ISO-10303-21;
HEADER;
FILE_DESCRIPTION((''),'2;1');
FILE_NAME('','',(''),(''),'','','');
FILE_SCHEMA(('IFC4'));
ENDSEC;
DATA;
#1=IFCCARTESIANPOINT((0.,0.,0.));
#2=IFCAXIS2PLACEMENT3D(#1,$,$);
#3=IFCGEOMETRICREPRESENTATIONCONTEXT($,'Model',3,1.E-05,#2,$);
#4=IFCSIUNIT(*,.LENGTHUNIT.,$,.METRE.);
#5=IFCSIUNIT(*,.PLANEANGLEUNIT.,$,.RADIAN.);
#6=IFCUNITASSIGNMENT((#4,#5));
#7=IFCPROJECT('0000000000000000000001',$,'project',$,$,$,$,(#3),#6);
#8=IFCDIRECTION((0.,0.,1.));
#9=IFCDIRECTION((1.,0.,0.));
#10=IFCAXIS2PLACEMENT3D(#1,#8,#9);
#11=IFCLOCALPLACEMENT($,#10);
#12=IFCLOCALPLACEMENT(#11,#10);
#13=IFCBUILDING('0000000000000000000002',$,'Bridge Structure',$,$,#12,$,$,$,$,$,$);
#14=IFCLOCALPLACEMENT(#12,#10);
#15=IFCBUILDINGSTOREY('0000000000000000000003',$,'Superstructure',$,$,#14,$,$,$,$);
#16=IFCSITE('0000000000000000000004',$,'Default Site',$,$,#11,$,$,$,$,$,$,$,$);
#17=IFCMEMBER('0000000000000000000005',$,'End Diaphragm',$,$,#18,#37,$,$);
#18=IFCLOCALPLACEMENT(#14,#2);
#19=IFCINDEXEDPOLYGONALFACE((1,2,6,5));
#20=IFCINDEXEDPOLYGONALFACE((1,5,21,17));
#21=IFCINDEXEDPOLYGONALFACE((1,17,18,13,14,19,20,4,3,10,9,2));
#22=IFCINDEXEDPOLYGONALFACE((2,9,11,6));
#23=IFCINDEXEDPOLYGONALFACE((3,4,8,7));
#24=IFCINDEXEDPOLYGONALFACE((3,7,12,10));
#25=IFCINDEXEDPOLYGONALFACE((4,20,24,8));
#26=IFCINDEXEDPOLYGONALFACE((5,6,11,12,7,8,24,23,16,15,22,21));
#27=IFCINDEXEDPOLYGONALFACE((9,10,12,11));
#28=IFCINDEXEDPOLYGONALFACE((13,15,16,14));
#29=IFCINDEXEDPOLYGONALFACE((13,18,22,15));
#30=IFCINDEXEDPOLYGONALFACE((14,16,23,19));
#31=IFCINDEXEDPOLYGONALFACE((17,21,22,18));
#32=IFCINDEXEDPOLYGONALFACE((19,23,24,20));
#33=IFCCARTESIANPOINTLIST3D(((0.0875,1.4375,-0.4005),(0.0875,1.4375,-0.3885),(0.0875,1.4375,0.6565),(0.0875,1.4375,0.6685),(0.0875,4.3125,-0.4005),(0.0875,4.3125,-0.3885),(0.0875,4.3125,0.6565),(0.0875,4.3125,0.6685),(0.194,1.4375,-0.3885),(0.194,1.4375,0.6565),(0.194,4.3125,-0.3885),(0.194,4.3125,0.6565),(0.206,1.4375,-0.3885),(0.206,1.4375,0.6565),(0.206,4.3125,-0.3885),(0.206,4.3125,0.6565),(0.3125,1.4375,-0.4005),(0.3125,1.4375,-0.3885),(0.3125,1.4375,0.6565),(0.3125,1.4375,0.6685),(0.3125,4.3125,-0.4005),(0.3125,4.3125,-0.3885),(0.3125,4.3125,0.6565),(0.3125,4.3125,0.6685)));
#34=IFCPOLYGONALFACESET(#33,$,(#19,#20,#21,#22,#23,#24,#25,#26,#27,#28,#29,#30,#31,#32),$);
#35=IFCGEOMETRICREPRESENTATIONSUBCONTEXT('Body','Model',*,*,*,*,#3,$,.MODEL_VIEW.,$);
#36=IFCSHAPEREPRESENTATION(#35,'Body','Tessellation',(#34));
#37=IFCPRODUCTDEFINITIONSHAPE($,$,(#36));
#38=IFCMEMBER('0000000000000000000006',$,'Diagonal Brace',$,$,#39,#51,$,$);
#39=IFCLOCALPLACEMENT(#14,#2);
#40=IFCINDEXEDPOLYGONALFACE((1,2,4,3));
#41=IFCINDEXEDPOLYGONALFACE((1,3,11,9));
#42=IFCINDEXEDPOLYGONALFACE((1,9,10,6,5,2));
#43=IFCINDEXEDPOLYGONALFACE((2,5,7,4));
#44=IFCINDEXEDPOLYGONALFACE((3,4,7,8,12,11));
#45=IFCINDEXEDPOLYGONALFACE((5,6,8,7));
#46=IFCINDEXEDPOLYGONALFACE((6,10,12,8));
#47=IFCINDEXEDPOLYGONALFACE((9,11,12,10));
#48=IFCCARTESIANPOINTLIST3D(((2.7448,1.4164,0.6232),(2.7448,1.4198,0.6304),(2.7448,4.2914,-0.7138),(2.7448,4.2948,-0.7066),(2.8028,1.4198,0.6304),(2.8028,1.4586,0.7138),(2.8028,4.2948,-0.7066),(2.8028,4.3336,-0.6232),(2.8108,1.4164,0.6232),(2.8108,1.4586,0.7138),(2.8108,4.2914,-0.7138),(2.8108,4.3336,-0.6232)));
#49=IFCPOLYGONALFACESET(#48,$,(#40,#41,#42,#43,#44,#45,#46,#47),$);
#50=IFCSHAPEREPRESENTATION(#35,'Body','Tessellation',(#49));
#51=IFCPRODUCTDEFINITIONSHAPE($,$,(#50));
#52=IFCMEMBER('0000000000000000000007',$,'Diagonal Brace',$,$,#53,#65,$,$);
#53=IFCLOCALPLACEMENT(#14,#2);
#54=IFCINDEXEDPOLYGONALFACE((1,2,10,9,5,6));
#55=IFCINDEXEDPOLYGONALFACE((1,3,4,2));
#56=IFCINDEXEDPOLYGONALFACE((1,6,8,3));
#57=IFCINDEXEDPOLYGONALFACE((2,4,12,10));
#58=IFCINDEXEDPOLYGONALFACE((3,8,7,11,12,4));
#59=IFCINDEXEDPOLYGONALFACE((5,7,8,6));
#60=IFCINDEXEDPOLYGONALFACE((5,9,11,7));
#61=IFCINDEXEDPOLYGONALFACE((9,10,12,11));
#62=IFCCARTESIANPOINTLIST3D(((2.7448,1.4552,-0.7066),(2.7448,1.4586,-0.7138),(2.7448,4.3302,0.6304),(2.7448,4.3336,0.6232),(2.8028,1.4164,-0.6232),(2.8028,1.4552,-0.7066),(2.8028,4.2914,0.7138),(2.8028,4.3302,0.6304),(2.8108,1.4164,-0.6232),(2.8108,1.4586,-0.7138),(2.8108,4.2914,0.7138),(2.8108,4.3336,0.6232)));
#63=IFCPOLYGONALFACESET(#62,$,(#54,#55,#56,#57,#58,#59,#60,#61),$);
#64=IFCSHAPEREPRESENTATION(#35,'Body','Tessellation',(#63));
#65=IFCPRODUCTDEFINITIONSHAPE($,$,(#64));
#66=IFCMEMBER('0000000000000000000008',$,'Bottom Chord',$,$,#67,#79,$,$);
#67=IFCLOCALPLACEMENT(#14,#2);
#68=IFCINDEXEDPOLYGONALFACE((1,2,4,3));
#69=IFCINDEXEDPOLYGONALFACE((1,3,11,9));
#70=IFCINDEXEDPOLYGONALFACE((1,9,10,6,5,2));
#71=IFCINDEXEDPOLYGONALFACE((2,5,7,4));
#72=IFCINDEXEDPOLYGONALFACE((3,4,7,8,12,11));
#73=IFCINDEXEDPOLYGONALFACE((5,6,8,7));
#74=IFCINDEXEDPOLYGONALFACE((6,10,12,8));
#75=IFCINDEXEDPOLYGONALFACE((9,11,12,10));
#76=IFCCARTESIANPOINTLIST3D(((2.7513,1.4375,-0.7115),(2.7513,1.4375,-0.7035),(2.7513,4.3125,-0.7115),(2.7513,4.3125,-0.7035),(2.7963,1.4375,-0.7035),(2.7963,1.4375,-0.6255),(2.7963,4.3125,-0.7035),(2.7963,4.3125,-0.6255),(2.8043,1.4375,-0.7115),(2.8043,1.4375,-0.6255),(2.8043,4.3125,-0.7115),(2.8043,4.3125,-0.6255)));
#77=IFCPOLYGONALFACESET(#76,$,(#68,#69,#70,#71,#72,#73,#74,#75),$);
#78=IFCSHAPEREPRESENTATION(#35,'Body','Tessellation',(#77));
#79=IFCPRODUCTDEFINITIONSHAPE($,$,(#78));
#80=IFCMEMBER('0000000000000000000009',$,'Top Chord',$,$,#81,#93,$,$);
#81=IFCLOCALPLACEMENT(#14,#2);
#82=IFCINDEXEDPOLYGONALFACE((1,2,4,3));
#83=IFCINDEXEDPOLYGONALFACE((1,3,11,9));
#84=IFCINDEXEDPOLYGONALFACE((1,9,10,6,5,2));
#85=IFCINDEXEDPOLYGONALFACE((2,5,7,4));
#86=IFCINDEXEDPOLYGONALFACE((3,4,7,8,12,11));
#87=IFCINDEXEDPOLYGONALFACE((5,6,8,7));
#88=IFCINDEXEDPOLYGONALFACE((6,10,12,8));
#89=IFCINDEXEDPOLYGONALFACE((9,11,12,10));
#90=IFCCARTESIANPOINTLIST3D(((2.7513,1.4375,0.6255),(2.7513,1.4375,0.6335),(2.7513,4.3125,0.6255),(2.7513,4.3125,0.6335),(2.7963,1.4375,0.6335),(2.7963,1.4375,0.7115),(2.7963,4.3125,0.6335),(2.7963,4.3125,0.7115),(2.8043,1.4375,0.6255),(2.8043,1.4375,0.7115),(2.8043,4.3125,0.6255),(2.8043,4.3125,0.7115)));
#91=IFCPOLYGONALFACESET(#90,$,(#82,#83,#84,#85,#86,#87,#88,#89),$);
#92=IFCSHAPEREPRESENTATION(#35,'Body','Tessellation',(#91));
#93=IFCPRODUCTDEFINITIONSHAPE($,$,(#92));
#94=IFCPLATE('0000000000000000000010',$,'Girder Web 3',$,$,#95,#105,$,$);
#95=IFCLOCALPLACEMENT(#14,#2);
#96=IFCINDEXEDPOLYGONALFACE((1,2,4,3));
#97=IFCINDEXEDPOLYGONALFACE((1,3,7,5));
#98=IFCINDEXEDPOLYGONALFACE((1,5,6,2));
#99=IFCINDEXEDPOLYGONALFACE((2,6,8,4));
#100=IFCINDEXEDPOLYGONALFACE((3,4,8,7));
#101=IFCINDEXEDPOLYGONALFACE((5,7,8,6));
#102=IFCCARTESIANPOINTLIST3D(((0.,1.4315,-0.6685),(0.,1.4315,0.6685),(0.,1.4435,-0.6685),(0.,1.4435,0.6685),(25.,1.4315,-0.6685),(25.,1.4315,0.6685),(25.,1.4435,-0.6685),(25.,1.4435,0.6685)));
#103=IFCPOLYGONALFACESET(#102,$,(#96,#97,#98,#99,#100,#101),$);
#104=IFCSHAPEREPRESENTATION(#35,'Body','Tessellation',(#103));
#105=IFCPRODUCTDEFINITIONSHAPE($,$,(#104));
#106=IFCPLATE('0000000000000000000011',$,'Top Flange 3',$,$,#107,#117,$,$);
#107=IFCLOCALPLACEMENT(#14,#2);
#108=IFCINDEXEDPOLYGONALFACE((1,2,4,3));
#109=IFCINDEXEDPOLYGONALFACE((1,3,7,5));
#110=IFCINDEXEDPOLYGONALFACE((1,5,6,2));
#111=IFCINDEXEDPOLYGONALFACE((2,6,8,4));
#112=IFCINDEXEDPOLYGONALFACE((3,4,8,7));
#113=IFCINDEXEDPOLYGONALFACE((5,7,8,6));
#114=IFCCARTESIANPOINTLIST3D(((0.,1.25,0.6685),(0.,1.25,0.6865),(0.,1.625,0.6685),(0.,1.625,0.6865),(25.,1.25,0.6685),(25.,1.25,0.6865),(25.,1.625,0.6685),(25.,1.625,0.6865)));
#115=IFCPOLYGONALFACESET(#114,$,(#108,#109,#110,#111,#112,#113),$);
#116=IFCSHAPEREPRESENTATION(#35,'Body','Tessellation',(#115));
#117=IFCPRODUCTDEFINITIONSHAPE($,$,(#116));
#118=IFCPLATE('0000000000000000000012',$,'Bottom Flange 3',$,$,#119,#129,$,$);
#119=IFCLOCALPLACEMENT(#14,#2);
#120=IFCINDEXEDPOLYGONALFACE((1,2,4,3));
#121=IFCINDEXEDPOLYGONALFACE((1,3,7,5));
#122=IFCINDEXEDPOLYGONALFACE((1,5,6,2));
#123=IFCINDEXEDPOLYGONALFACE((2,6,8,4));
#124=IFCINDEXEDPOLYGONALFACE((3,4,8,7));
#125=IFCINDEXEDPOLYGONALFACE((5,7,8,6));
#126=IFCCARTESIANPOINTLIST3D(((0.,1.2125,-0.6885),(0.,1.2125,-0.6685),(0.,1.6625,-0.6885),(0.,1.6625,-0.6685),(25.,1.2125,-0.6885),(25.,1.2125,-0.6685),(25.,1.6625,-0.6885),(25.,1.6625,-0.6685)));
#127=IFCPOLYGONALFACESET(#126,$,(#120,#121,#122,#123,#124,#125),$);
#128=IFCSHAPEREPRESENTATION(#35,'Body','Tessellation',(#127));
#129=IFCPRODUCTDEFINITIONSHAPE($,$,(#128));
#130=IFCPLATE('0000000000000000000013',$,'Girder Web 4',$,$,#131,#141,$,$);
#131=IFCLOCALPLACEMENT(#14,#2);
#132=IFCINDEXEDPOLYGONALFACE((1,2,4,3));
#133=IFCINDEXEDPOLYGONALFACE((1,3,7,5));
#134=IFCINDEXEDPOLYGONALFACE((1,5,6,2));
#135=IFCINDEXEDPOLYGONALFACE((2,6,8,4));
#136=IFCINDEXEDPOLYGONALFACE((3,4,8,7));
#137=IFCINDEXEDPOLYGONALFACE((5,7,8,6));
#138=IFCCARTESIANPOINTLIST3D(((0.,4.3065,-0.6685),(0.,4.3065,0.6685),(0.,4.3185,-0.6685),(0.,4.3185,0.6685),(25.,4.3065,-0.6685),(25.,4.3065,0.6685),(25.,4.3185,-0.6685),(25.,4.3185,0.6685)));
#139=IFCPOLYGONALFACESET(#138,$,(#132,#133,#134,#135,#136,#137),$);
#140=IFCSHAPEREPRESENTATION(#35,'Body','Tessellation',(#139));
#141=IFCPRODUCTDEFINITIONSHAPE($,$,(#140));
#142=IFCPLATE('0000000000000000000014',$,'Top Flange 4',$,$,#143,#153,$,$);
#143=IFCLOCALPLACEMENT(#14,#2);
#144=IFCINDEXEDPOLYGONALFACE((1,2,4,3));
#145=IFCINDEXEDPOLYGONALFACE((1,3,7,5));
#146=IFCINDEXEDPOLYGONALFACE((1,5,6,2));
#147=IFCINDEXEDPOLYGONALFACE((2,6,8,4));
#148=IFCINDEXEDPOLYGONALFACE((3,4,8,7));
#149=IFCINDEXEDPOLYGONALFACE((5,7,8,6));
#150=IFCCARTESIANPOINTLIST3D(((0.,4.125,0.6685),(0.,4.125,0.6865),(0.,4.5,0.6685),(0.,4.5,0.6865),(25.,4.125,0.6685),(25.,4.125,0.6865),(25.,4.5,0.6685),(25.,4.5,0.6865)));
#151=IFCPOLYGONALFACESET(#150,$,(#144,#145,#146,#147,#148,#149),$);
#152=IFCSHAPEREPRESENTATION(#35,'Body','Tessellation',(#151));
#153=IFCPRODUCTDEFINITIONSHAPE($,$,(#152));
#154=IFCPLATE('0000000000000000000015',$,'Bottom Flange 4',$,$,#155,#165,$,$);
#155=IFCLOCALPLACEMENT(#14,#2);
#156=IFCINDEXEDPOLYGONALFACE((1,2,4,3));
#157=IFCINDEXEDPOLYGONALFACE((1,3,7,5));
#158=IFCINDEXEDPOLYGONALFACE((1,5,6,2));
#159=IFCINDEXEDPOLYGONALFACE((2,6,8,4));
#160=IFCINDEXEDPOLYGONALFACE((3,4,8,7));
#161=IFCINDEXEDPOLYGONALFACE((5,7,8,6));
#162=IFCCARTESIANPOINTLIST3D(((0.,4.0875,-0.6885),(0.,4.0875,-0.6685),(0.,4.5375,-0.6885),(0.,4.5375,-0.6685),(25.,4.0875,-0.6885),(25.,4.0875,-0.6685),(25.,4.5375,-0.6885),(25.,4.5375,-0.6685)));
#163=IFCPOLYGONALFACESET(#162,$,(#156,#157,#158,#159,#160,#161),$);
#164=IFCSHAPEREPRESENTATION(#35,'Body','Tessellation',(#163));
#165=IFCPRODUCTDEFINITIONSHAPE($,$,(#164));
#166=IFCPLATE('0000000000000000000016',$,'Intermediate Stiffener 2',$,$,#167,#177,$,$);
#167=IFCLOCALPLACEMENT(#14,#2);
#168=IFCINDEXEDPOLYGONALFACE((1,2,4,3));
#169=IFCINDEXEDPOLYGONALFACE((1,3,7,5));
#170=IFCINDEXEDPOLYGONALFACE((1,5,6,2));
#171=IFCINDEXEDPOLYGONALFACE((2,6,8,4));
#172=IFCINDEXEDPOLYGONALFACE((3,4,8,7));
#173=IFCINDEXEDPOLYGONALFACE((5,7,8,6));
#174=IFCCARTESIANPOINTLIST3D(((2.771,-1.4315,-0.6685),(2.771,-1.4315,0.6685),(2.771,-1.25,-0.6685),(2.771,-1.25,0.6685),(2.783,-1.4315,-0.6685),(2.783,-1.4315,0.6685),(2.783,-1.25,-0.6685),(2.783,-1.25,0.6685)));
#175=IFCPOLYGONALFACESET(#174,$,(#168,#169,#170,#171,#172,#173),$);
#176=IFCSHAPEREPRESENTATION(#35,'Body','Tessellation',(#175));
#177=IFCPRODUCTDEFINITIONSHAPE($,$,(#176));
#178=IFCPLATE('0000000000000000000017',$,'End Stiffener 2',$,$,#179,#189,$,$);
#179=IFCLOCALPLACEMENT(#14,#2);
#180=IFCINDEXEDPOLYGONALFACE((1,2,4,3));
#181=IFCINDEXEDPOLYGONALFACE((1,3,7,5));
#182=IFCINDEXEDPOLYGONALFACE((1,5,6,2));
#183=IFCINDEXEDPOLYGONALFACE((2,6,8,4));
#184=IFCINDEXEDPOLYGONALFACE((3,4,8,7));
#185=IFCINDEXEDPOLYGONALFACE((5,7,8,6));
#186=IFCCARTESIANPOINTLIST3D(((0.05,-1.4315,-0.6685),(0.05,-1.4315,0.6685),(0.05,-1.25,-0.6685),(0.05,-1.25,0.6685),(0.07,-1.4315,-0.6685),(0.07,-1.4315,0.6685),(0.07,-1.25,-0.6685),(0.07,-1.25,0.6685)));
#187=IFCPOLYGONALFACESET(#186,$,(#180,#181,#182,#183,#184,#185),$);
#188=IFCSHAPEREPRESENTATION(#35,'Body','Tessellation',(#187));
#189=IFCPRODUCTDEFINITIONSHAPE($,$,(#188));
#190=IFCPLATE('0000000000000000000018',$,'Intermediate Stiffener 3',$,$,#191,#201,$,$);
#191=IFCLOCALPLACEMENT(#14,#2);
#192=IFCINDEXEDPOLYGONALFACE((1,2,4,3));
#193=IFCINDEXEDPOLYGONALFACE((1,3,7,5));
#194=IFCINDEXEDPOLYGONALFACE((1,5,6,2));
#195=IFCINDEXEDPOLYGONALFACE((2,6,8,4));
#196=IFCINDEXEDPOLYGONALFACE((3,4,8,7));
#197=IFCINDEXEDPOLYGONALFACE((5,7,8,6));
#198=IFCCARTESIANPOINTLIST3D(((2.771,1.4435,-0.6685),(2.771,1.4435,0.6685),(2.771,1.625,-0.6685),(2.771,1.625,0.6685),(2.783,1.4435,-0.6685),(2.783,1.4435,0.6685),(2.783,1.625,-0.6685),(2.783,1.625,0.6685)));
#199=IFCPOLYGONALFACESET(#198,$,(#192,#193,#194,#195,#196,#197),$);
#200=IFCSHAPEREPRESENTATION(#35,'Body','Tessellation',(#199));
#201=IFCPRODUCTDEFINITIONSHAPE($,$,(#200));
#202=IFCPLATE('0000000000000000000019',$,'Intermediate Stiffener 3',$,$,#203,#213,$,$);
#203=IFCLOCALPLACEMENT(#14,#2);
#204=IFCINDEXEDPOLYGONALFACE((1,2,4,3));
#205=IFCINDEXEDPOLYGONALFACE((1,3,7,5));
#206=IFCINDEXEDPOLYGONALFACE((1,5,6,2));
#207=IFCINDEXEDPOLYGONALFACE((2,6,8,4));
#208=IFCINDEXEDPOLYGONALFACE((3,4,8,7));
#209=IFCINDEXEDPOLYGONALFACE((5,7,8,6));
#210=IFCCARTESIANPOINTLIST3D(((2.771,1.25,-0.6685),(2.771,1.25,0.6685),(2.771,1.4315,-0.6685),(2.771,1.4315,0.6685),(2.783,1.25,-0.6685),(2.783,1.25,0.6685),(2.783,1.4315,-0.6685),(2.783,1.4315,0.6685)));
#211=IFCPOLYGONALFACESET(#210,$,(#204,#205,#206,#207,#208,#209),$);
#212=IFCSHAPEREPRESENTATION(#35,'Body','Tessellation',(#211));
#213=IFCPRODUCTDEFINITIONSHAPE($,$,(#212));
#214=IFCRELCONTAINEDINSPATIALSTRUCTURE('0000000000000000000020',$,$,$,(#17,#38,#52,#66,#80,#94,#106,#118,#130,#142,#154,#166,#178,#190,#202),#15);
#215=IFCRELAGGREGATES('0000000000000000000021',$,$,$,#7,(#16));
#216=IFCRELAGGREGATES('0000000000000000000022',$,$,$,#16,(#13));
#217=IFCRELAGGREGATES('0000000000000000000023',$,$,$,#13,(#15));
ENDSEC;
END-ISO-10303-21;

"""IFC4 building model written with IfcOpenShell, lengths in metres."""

from ifc_helpers import new_model, si_unit, frame, origin, origin_with_axes, origin_2d_with_axis, place, context, subcontext, project, spatial, rectangle, i_section, l_section, extrude, element, save


model = new_model("IFC4")

# Units and contexts
model_context = context("Model", 3, precision=1e-05, world=origin())
body_context = subcontext(model_context, "Body", "Model", "MODEL_VIEW")
ifc_project = project(units=[si_unit("LENGTHUNIT", "METRE"), si_unit("PLANEANGLEUNIT", "RADIAN")], contexts=[model_context])

# Site, building, storey
site_placement = place(None, origin_with_axes())
site = spatial("IfcSite", under=ifc_project, at=site_placement, Name="Default Site")
building_placement = place(site_placement, origin_with_axes())
building = spatial("IfcBuilding", under=site, at=building_placement, Name="Bridge Structure")
storey_placement = place(building_placement, origin_with_axes())
storey = spatial("IfcBuildingStorey", under=building, at=storey_placement, Name="Superstructure")

# Members
member_placement = place(storey_placement, frame((0.2, 1.4375, 0.134), z_axis=(0.0, 1.0, 0.0), x_axis=(-1.0, 0.0, 0.0)))
element("IfcMember", 1, at=member_placement, inside=storey, Name="End Diaphragm", context=body_context, shape_type="SweptSolid", body=[
    extrude(i_section(OverallWidth=0.225, OverallDepth=1.069, WebThickness=0.012, FlangeThickness=0.012, at=origin_2d_with_axis()), origin_with_axes(), (0.0, 0.0, 1.0), 2.875),
])
for number, where, z_axis, x_axis, name in (
    (2, (2.7778, 1.4375, 0.6685), (0.0, 0.906746, -0.421676), (-1.0, 0.0, 0.0), "Diagonal Brace"),
    (3, (2.7778, 1.4375, -0.6685), (0.0, 0.906746, 0.421676), (-1.0, 0.0, 0.0), "Diagonal Brace"),
):
    element("IfcMember", number, at=place(storey_placement, frame(where, z_axis=z_axis, x_axis=x_axis)), inside=storey, Name=name, context=body_context, shape_type="SweptSolid", body=[
        extrude(l_section(Depth=0.1, Width=0.066, Thickness=0.008, at=origin_2d_with_axis()), origin_with_axes(), (0.0, 0.0, 1.0), 3.1707),
    ])
for number, where, z_axis, x_axis, name in (
    (4, (2.7778, 1.4375, -0.6685), (0.0, 1.0, 0.0), (-1.0, 0.0, 0.0), "Bottom Chord"),
    (5, (2.7778, 1.4375, 0.6685), (0.0, 1.0, 0.0), (-1.0, 0.0, 0.0), "Top Chord"),
):
    element("IfcMember", number, at=place(storey_placement, frame(where, z_axis=z_axis, x_axis=x_axis)), inside=storey, Name=name, context=body_context, shape_type="SweptSolid", body=[
        extrude(l_section(Depth=0.086, Width=0.053, Thickness=0.008, at=origin_2d_with_axis()), origin_with_axes(), (0.0, 0.0, 1.0), 2.875),
    ])

# Plates
plate_1_placement = place(storey_placement, frame((0.0, 1.4375, 0.0), z_axis=(1.0, 0.0, 0.0), x_axis=(0.0, 1.0, 0.0)))
element("IfcPlate", 6, at=plate_1_placement, inside=storey, Name="Girder Web 3", context=body_context, shape_type="SweptSolid", body=[
    extrude(rectangle(XDim=0.012, YDim=1.337, at=origin_2d_with_axis()), origin_with_axes(), (0.0, 0.0, 1.0), 25.0),
])
plate_2_placement = place(storey_placement, frame((0.0, 1.4375, 0.6775), z_axis=(1.0, 0.0, 0.0), x_axis=(0.0, 1.0, 0.0)))
element("IfcPlate", 7, at=plate_2_placement, inside=storey, Name="Top Flange 3", context=body_context, shape_type="SweptSolid", body=[
    extrude(rectangle(XDim=0.375, YDim=0.018, at=origin_2d_with_axis()), origin_with_axes(), (0.0, 0.0, 1.0), 25.0),
])
plate_3_placement = place(storey_placement, frame((0.0, 1.4375, -0.6785), z_axis=(1.0, 0.0, 0.0), x_axis=(0.0, 1.0, 0.0)))
element("IfcPlate", 8, at=plate_3_placement, inside=storey, Name="Bottom Flange 3", context=body_context, shape_type="SweptSolid", body=[
    extrude(rectangle(XDim=0.45, YDim=0.02, at=origin_2d_with_axis()), origin_with_axes(), (0.0, 0.0, 1.0), 25.0),
])
plate_4_placement = place(storey_placement, frame((0.0, 4.3125, 0.0), z_axis=(1.0, 0.0, 0.0), x_axis=(0.0, 1.0, 0.0)))
element("IfcPlate", 9, at=plate_4_placement, inside=storey, Name="Girder Web 4", context=body_context, shape_type="SweptSolid", body=[
    extrude(rectangle(XDim=0.012, YDim=1.337, at=origin_2d_with_axis()), origin_with_axes(), (0.0, 0.0, 1.0), 25.0),
])
plate_5_placement = place(storey_placement, frame((0.0, 4.3125, 0.6775), z_axis=(1.0, 0.0, 0.0), x_axis=(0.0, 1.0, 0.0)))
element("IfcPlate", 10, at=plate_5_placement, inside=storey, Name="Top Flange 4", context=body_context, shape_type="SweptSolid", body=[
    extrude(rectangle(XDim=0.375, YDim=0.018, at=origin_2d_with_axis()), origin_with_axes(), (0.0, 0.0, 1.0), 25.0),
])
plate_6_placement = place(storey_placement, frame((0.0, 4.3125, -0.6785), z_axis=(1.0, 0.0, 0.0), x_axis=(0.0, 1.0, 0.0)))
element("IfcPlate", 11, at=plate_6_placement, inside=storey, Name="Bottom Flange 4", context=body_context, shape_type="SweptSolid", body=[
    extrude(rectangle(XDim=0.45, YDim=0.02, at=origin_2d_with_axis()), origin_with_axes(), (0.0, 0.0, 1.0), 25.0),
])
plate_7_placement = place(storey_placement, frame((2.777, -1.3408, -0.6685), z_axis=(0.0, 0.0, 1.0), x_axis=(1.0, 0.0, 0.0)))
element("IfcPlate", 12, at=plate_7_placement, inside=storey, Name="Intermediate Stiffener 2", context=body_context, shape_type="SweptSolid", body=[
    extrude(rectangle(XDim=0.012, YDim=0.1815, at=origin_2d_with_axis()), origin_with_axes(), (0.0, 0.0, 1.0), 1.337),
])
plate_8_placement = place(storey_placement, frame((0.06, -1.3408, -0.6685), z_axis=(0.0, 0.0, 1.0), x_axis=(1.0, 0.0, 0.0)))
element("IfcPlate", 13, at=plate_8_placement, inside=storey, Name="End Stiffener 2", context=body_context, shape_type="SweptSolid", body=[
    extrude(rectangle(XDim=0.02, YDim=0.1815, at=origin_2d_with_axis()), origin_with_axes(), (0.0, 0.0, 1.0), 1.337),
])
for number, where, z_axis, x_axis, name in (
    (14, (2.777, 1.5343, -0.6685), (0.0, 0.0, 1.0), (1.0, 0.0, 0.0), "Intermediate Stiffener 3"),
    (15, (2.777, 1.3408, -0.6685), (0.0, 0.0, 1.0), (1.0, 0.0, 0.0), "Intermediate Stiffener 3"),
):
    element("IfcPlate", number, at=place(storey_placement, frame(where, z_axis=z_axis, x_axis=x_axis)), inside=storey, Name=name, context=body_context, shape_type="SweptSolid", body=[
        extrude(rectangle(XDim=0.012, YDim=0.1815, at=origin_2d_with_axis()), origin_with_axes(), (0.0, 0.0, 1.0), 1.337),
    ])

save(model, "model.ifc")
